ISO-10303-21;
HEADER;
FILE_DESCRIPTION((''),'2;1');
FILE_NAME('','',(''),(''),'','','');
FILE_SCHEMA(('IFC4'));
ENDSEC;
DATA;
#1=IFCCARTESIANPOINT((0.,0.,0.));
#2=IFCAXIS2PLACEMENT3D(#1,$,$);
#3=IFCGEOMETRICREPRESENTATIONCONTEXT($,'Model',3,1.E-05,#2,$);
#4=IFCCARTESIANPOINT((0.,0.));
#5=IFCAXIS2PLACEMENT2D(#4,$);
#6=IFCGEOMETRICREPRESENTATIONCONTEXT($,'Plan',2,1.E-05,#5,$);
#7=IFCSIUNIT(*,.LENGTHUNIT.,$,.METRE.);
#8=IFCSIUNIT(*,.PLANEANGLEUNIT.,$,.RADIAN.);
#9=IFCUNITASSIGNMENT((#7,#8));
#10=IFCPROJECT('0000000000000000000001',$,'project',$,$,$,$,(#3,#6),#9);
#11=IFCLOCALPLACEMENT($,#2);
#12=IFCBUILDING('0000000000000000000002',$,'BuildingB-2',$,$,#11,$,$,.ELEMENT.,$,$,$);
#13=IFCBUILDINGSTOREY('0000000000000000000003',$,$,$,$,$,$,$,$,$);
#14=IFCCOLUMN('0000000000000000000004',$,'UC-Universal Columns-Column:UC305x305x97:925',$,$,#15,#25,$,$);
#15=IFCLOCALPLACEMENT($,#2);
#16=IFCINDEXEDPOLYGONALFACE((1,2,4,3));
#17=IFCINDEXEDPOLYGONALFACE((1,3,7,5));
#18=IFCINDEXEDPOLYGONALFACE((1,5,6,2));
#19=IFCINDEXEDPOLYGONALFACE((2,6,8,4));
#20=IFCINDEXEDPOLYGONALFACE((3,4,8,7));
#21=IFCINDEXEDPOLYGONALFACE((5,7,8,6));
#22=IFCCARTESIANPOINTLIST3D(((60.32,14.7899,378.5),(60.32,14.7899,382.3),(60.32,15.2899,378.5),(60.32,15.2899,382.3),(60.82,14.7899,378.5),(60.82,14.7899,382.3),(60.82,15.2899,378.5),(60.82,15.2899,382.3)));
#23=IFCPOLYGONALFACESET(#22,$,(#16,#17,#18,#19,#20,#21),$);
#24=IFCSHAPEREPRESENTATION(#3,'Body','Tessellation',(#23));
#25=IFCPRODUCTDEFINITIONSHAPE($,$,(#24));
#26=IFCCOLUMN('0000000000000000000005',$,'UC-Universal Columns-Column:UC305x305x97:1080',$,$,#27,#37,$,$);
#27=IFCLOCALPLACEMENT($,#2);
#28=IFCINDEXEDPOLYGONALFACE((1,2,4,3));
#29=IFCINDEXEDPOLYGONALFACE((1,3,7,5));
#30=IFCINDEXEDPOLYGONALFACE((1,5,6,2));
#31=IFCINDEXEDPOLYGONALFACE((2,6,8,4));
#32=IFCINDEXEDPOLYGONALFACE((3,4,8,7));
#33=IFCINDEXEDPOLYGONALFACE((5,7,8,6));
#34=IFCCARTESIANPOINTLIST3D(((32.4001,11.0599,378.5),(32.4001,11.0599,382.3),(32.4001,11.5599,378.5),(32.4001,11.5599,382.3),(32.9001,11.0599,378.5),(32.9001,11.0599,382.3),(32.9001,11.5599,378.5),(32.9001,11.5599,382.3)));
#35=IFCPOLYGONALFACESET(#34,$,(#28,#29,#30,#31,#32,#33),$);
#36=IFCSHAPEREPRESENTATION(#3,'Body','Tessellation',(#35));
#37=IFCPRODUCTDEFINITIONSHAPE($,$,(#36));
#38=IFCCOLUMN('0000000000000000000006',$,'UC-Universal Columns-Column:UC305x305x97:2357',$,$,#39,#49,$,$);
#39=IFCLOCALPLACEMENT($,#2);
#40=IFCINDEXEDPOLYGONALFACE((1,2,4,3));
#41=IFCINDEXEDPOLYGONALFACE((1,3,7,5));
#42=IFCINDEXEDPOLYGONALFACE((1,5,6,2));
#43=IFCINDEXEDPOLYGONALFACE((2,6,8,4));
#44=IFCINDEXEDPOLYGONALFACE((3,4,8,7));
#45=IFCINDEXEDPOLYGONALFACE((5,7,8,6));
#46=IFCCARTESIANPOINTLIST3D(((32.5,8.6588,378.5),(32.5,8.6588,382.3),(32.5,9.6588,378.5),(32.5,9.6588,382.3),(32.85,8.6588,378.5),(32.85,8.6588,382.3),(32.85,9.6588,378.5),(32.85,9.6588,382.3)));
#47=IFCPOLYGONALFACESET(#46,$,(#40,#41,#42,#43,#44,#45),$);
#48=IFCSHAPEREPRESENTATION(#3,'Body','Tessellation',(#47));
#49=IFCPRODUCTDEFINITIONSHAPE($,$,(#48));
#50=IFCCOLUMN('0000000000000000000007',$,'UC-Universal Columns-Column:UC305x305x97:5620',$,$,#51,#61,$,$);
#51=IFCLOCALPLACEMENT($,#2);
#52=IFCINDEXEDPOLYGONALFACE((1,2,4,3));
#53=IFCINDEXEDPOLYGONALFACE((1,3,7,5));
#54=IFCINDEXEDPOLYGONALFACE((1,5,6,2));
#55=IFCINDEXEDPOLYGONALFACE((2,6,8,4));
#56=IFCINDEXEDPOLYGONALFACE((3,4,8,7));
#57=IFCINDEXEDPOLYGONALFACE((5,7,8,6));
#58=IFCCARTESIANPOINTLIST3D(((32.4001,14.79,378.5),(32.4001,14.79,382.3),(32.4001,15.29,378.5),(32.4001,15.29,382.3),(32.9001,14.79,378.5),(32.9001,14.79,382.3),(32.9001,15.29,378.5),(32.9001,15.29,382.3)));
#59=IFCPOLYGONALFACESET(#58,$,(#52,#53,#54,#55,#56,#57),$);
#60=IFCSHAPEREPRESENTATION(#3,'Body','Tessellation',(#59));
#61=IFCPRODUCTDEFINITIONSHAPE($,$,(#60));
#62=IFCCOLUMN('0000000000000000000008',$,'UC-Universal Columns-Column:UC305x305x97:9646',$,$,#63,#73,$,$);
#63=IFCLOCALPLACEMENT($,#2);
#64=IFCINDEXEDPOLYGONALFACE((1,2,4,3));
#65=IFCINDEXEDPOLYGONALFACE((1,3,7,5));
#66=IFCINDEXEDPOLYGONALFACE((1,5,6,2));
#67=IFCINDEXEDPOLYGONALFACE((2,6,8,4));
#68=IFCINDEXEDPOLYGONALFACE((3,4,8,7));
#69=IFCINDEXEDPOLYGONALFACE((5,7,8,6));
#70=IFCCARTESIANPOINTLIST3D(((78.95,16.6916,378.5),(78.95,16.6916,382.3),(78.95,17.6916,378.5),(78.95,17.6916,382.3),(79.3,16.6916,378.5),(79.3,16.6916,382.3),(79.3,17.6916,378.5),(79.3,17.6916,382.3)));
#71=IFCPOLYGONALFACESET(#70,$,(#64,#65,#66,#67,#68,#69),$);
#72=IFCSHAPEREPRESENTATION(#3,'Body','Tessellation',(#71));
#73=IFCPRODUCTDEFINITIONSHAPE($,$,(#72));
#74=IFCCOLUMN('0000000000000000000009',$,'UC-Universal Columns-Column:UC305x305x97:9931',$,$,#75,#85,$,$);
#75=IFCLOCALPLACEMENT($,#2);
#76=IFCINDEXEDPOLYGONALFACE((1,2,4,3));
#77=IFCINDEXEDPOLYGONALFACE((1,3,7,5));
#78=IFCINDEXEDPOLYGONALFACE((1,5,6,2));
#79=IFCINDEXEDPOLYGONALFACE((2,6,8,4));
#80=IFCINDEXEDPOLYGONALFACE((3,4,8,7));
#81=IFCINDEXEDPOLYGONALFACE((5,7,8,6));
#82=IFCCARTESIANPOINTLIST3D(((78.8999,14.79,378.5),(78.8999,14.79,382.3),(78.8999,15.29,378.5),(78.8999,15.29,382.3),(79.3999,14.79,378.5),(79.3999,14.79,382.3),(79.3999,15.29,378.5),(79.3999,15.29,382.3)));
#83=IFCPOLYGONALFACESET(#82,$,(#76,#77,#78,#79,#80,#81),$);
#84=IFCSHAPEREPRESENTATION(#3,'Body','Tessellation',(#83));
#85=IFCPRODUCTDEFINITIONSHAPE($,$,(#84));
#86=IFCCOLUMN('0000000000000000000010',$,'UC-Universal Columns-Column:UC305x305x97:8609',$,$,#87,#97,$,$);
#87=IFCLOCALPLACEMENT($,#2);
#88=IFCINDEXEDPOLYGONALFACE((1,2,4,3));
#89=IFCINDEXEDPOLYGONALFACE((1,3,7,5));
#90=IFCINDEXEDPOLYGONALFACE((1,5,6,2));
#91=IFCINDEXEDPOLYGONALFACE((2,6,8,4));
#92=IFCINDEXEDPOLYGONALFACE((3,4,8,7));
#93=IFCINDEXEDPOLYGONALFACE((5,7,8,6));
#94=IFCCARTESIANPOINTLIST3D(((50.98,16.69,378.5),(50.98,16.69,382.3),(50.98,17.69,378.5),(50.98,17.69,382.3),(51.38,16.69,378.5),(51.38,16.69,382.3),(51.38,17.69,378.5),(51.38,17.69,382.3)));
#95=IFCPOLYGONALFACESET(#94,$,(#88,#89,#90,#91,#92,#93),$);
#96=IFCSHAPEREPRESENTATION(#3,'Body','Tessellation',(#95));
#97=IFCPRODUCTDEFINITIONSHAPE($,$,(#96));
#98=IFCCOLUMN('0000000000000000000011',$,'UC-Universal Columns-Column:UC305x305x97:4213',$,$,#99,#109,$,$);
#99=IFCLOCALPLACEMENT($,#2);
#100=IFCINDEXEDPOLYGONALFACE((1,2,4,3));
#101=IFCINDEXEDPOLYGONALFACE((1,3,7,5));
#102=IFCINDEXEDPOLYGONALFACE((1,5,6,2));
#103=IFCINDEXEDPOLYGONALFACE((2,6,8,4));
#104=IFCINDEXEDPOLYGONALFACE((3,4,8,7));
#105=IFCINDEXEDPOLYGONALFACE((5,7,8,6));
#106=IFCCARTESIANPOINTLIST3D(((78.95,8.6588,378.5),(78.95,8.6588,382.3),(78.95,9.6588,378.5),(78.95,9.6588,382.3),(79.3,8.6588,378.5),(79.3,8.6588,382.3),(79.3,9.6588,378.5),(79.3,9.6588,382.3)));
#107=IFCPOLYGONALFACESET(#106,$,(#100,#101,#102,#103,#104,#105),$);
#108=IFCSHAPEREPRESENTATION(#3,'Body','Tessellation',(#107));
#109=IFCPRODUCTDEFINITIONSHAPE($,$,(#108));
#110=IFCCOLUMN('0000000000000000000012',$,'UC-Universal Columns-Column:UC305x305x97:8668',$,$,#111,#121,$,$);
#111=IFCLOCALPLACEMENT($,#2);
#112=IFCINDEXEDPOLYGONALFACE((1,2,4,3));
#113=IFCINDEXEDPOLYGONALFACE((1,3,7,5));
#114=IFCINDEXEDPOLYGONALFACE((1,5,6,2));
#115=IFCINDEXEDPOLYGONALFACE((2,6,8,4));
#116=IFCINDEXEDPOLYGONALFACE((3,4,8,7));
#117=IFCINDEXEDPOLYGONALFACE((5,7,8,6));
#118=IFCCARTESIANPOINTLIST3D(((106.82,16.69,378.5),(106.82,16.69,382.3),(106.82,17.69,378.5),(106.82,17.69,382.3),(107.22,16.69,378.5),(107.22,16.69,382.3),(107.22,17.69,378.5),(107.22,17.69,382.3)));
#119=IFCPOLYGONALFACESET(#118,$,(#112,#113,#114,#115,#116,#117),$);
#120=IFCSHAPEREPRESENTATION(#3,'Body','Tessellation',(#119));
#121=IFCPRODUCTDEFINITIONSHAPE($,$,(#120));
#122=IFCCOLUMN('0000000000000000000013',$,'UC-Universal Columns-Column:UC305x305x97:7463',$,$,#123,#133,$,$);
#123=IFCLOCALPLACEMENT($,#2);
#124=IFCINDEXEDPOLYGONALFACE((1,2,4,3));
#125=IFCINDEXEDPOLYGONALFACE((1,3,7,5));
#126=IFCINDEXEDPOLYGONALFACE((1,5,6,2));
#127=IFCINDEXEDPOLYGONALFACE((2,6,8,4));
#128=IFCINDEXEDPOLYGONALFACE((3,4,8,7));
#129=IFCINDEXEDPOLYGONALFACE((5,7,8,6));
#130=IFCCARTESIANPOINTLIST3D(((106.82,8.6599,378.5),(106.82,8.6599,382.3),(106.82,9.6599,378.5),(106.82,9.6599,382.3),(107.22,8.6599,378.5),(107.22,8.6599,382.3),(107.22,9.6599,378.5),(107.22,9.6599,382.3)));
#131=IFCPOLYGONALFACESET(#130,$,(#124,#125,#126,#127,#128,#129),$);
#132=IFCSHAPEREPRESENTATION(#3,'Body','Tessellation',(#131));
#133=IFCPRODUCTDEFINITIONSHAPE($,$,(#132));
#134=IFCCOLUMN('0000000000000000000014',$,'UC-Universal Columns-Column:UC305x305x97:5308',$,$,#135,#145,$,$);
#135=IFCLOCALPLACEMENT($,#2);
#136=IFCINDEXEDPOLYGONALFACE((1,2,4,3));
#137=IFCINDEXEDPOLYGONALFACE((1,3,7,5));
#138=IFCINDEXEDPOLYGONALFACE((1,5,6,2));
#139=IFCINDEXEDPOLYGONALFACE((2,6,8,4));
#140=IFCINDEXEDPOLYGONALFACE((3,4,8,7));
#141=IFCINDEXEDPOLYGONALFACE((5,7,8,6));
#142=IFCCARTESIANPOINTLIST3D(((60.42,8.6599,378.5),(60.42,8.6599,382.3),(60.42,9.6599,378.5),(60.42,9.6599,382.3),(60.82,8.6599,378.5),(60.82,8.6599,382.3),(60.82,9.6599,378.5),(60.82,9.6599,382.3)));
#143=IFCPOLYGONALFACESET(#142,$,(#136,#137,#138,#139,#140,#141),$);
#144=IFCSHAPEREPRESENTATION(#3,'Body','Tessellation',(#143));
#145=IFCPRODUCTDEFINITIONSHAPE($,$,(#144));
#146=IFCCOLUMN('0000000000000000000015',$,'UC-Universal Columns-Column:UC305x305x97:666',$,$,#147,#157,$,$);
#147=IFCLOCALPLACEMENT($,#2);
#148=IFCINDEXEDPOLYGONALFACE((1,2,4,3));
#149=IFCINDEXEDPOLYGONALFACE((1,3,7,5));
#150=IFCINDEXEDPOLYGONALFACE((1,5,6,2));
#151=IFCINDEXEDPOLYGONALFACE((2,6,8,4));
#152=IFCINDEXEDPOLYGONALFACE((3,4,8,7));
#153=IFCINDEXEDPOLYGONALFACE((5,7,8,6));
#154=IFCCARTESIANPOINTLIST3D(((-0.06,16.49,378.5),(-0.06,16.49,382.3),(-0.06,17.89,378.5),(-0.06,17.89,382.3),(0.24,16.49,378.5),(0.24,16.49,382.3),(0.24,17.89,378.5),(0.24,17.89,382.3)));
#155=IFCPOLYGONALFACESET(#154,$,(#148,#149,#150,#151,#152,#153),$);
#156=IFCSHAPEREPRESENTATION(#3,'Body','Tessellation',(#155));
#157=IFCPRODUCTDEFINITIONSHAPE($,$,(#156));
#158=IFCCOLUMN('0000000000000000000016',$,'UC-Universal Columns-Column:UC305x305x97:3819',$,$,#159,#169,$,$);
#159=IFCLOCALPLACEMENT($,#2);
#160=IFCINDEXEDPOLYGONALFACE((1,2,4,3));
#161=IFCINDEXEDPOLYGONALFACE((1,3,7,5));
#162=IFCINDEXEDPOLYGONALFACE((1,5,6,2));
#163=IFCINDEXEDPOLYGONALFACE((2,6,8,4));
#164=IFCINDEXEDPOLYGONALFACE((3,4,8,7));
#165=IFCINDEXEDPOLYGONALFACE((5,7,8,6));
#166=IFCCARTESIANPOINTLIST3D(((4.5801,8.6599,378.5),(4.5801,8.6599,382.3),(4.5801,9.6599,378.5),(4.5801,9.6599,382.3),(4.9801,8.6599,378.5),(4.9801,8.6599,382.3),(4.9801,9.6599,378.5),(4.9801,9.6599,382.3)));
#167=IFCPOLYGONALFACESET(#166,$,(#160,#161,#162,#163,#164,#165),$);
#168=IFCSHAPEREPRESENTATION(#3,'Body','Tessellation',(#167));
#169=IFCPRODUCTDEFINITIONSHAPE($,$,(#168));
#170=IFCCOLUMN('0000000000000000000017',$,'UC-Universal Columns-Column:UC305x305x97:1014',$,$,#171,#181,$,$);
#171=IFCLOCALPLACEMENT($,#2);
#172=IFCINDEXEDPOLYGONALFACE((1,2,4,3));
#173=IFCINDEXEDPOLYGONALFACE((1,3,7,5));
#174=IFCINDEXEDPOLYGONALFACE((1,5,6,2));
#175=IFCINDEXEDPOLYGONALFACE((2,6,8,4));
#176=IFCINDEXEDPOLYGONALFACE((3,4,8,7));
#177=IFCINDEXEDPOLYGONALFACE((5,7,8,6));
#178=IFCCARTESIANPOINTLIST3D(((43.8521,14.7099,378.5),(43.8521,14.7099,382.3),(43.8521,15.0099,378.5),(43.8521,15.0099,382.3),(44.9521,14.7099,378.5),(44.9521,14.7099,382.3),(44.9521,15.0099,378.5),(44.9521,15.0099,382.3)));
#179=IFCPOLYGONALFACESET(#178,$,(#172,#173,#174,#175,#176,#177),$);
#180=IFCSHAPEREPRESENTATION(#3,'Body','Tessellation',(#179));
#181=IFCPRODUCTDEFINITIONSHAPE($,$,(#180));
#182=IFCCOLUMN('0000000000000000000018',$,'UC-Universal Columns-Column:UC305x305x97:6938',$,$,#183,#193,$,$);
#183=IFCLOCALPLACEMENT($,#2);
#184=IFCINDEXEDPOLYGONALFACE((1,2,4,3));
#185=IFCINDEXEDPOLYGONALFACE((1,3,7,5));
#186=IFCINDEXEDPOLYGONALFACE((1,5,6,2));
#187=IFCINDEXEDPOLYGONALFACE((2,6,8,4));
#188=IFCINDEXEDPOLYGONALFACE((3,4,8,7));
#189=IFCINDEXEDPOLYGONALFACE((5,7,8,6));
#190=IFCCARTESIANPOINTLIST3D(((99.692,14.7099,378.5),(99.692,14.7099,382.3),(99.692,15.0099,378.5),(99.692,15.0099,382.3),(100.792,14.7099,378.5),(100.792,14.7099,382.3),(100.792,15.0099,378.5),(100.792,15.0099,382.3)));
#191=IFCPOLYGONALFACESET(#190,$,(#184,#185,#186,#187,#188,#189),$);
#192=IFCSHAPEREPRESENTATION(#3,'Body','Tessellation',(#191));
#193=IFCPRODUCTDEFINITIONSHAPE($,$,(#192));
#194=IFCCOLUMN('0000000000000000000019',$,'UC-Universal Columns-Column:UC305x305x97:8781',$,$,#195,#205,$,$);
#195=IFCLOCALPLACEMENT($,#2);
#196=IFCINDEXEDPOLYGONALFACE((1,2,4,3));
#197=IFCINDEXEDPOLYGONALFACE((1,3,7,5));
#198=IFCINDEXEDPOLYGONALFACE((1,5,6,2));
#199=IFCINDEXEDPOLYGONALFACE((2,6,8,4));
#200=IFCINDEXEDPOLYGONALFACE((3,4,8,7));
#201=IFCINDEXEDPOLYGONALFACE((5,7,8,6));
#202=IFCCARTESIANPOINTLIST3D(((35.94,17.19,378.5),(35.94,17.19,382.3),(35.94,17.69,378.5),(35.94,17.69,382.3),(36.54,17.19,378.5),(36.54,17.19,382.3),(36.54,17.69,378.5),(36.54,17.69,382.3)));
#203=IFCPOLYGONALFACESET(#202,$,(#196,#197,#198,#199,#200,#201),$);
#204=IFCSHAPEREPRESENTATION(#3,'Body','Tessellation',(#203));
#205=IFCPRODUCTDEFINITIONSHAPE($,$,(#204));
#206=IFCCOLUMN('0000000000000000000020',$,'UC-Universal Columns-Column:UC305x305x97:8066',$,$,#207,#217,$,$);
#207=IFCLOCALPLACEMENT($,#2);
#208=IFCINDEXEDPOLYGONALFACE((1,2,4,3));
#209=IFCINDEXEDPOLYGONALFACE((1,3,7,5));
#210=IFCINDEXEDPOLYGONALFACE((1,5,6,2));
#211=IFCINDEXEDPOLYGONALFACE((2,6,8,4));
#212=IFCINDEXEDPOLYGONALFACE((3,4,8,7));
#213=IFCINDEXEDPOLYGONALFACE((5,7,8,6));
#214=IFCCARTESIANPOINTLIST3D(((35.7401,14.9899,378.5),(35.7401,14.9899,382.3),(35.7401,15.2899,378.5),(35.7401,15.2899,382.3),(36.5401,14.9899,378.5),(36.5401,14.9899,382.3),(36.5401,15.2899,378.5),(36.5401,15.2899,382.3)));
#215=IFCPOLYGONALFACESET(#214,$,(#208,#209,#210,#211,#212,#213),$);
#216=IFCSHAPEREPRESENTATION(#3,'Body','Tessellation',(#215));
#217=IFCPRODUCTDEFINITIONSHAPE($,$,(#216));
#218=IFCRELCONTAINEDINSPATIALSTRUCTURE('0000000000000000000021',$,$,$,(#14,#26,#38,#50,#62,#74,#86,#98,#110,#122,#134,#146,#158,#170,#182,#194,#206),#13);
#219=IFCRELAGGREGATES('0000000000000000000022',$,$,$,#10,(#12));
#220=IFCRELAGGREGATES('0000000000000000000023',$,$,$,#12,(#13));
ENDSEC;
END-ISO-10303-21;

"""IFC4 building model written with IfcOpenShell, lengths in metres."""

from ifc_helpers import new_model, si_unit, origin, origin_2d, place, context, project, spatial, polyline, outline, extrude, element, save


model = new_model("IFC4")

# Units and contexts
model_context = context("Model", 3, precision=1e-05, world=origin())
plan_context = context("Plan", 2, precision=1e-05, world=origin_2d())
ifc_project = project(units=[si_unit("LENGTHUNIT", "METRE"), si_unit("PLANEANGLEUNIT", "RADIAN")], contexts=[model_context, plan_context])

# Building, storey
building_placement = place(None, origin())
building = spatial("IfcBuilding", under=ifc_project, at=building_placement, Name="BuildingB-2", CompositionType="ELEMENT")
storey = spatial("IfcBuildingStorey", under=building)

# Columns
element("IfcColumn", 1, inside=storey, Name="UC-Universal Columns-Column:UC305x305x97:925", context=model_context, shape_type="SweptSolid", body=[
    extrude(outline(polyline([(60.82, 15.2899, 382.3), (60.32, 15.2899, 382.3), (60.32, 14.7899, 382.3), (60.82, 14.7899, 382.3), (60.82, 15.2899, 382.3)])), None, (0.0, 0.0, -1.0), 3.8),
])
element("IfcColumn", 2, inside=storey, Name="UC-Universal Columns-Column:UC305x305x97:1080", context=model_context, shape_type="SweptSolid", body=[
    extrude(outline(polyline([(32.9001, 11.0599, 382.3), (32.4001, 11.0599, 382.3), (32.4001, 11.5599, 382.3), (32.9001, 11.5599, 382.3), (32.9001, 11.0599, 382.3)])), None, (0.0, 0.0, -1.0), 3.8),
])
element("IfcColumn", 3, inside=storey, Name="UC-Universal Columns-Column:UC305x305x97:2357", context=model_context, shape_type="SweptSolid", body=[
    extrude(outline(polyline([(32.5, 8.6588, 382.3), (32.85, 8.6588, 382.3), (32.85, 9.6588, 382.3), (32.5, 9.6588, 382.3), (32.5, 8.6588, 382.3)])), None, (0.0, 0.0, -1.0), 3.8),
])
element("IfcColumn", 4, inside=storey, Name="UC-Universal Columns-Column:UC305x305x97:5620", context=model_context, shape_type="SweptSolid", body=[
    extrude(outline(polyline([(32.9001, 15.29, 382.3), (32.4001, 15.29, 382.3), (32.4001, 14.79, 382.3), (32.9001, 14.79, 382.3), (32.9001, 15.29, 382.3)])), None, (0.0, 0.0, -1.0), 3.8),
])
element("IfcColumn", 5, inside=storey, Name="UC-Universal Columns-Column:UC305x305x97:9646", context=model_context, shape_type="SweptSolid", body=[
    extrude(outline(polyline([(79.3, 17.6916, 382.3), (78.95, 17.6916, 382.3), (78.95, 16.6916, 382.3), (79.3, 16.6916, 382.3), (79.3, 17.6916, 382.3)])), None, (0.0, 0.0, -1.0), 3.8),
])
element("IfcColumn", 6, inside=storey, Name="UC-Universal Columns-Column:UC305x305x97:9931", context=model_context, shape_type="SweptSolid", body=[
    extrude(outline(polyline([(78.8999, 15.29, 382.3), (79.3999, 15.29, 382.3), (79.3999, 14.79, 382.3), (78.8999, 14.79, 382.3), (78.8999, 15.29, 382.3)])), None, (0.0, 0.0, -1.0), 3.8),
])
element("IfcColumn", 7, inside=storey, Name="UC-Universal Columns-Column:UC305x305x97:8609", context=model_context, shape_type="SweptSolid", body=[
    extrude(outline(polyline([(51.38, 17.69, 382.3), (50.98, 17.69, 382.3), (50.98, 16.69, 382.3), (51.38, 16.69, 382.3), (51.38, 17.69, 382.3)])), None, (0.0, 0.0, -1.0), 3.8),
])
element("IfcColumn", 8, inside=storey, Name="UC-Universal Columns-Column:UC305x305x97:4213", context=model_context, shape_type="SweptSolid", body=[
    extrude(outline(polyline([(79.3, 8.6588, 382.3), (78.95, 8.6588, 382.3), (78.95, 9.6588, 382.3), (79.3, 9.6588, 382.3), (79.3, 8.6588, 382.3)])), None, (0.0, 0.0, -1.0), 3.8),
])
element("IfcColumn", 9, inside=storey, Name="UC-Universal Columns-Column:UC305x305x97:8668", context=model_context, shape_type="SweptSolid", body=[
    extrude(outline(polyline([(107.22, 17.69, 382.3), (106.82, 17.69, 382.3), (106.82, 16.69, 382.3), (107.22, 16.69, 382.3), (107.22, 17.69, 382.3)])), None, (0.0, 0.0, -1.0), 3.8),
])
element("IfcColumn", 10, inside=storey, Name="UC-Universal Columns-Column:UC305x305x97:7463", context=model_context, shape_type="SweptSolid", body=[
    extrude(outline(polyline([(107.22, 8.6599, 382.3), (106.82, 8.6599, 382.3), (106.82, 9.6599, 382.3), (107.22, 9.6599, 382.3), (107.22, 8.6599, 382.3)])), None, (0.0, 0.0, -1.0), 3.8),
])
element("IfcColumn", 11, inside=storey, Name="UC-Universal Columns-Column:UC305x305x97:5308", context=model_context, shape_type="SweptSolid", body=[
    extrude(outline(polyline([(60.42, 8.6599, 382.3), (60.82, 8.6599, 382.3), (60.82, 9.6599, 382.3), (60.42, 9.6599, 382.3), (60.42, 8.6599, 382.3)])), None, (0.0, 0.0, -1.0), 3.8),
])
element("IfcColumn", 12, inside=storey, Name="UC-Universal Columns-Column:UC305x305x97:666", context=model_context, shape_type="SweptSolid", body=[
    extrude(outline(polyline([(-0.06, 17.89, 382.3), (0.24, 17.89, 382.3), (0.24, 16.49, 382.3), (-0.06, 16.49, 382.3), (-0.06, 17.89, 382.3)])), None, (0.0, 0.0, -1.0), 3.8),
])
element("IfcColumn", 13, inside=storey, Name="UC-Universal Columns-Column:UC305x305x97:3819", context=model_context, shape_type="SweptSolid", body=[
    extrude(outline(polyline([(4.5801, 8.6599, 382.3), (4.9801, 8.6599, 382.3), (4.9801, 9.6599, 382.3), (4.5801, 9.6599, 382.3), (4.5801, 8.6599, 382.3)])), None, (0.0, 0.0, -1.0), 3.8),
])
element("IfcColumn", 14, inside=storey, Name="UC-Universal Columns-Column:UC305x305x97:1014", context=model_context, shape_type="SweptSolid", body=[
    extrude(outline(polyline([(44.9521, 14.7099, 382.3), (44.9521, 15.0099, 382.3), (43.8521, 15.0099, 382.3), (43.8521, 14.7099, 382.3), (44.9521, 14.7099, 382.3)])), None, (0.0, 0.0, -1.0), 3.8),
])
element("IfcColumn", 15, inside=storey, Name="UC-Universal Columns-Column:UC305x305x97:6938", context=model_context, shape_type="SweptSolid", body=[
    extrude(outline(polyline([(100.792, 14.7099, 382.3), (100.792, 15.0099, 382.3), (99.692, 15.0099, 382.3), (99.692, 14.7099, 382.3), (100.792, 14.7099, 382.3)])), None, (0.0, 0.0, -1.0), 3.8),
])
element("IfcColumn", 16, inside=storey, Name="UC-Universal Columns-Column:UC305x305x97:8781", context=model_context, shape_type="SweptSolid", body=[
    extrude(outline(polyline([(36.54, 17.69, 382.3), (35.94, 17.69, 382.3), (35.94, 17.19, 382.3), (36.54, 17.19, 382.3), (36.54, 17.69, 382.3)])), None, (0.0, 0.0, -1.0), 3.8),
])
element("IfcColumn", 17, inside=storey, Name="UC-Universal Columns-Column:UC305x305x97:8066", context=model_context, shape_type="SweptSolid", body=[
    extrude(outline(polyline([(36.5401, 15.2899, 382.3), (35.7401, 15.2899, 382.3), (35.7401, 14.9899, 382.3), (36.5401, 14.9899, 382.3), (36.5401, 15.2899, 382.3)])), None, (0.0, 0.0, -1.0), 3.8),
])

save(model, "model.ifc")
